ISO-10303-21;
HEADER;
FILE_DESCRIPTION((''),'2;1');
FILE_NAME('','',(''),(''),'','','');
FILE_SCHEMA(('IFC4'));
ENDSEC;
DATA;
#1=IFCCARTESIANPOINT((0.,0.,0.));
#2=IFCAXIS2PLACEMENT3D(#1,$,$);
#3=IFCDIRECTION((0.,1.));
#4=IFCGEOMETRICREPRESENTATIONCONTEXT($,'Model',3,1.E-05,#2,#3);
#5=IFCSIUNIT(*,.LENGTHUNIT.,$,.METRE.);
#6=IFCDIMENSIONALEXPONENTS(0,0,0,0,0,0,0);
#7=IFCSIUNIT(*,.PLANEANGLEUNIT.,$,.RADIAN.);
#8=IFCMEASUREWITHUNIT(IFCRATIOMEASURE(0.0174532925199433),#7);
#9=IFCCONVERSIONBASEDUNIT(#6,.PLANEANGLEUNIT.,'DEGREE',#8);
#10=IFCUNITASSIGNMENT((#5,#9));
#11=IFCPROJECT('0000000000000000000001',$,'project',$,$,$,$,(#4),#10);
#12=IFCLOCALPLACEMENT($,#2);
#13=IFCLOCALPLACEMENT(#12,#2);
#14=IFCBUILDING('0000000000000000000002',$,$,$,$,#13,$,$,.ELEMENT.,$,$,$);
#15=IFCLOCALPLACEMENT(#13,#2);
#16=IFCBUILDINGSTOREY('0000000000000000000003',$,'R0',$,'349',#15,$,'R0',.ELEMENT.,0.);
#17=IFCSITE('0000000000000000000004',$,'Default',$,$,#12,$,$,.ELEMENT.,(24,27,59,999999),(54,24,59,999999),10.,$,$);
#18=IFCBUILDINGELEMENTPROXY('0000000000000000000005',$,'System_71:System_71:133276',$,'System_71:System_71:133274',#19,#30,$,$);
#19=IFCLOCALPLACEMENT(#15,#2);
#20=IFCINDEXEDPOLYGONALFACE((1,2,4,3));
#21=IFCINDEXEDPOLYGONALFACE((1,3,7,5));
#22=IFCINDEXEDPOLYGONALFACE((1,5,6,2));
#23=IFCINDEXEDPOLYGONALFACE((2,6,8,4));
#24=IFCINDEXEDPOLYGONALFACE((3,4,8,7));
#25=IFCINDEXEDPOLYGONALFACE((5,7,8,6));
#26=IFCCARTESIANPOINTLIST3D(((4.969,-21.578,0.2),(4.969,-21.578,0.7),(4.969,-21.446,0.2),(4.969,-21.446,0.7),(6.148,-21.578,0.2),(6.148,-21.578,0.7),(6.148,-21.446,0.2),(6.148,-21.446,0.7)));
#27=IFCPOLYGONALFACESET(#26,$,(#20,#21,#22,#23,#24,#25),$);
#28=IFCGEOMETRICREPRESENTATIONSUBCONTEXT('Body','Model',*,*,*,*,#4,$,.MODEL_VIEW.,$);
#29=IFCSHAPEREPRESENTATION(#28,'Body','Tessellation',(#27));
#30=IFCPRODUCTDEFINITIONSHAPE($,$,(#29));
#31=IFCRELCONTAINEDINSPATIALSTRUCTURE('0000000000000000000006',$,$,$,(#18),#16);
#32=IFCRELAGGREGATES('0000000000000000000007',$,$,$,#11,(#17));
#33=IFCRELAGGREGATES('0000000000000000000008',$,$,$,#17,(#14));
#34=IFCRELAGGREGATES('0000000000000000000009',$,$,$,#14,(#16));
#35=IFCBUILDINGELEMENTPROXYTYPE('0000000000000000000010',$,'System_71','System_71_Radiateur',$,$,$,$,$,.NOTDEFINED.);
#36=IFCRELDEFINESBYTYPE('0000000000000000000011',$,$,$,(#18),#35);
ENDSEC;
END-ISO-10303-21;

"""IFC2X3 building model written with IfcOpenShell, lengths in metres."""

from ifc_helpers import new_model, entity, si_unit, converted_unit, direction, frame, origin, origin_2d_with_axis, place, context, subcontext, project, spatial, rectangle, extrude, source, transform, mapped, type_object, type_shapes, element, save


model = new_model("IFC2X3")

# Units and contexts
model_context = context("Model", 3, precision=1e-05, world=origin(), true_north=direction((0.0, 1.0)))
body_context = subcontext(model_context, "Body", "Model", "MODEL_VIEW")
ifc_project = project(units=[si_unit("LENGTHUNIT", "METRE"), converted_unit("PLANEANGLEUNIT", "DEGREE", entity("IfcRatioMeasure", 0.0174532925199433), si_unit("PLANEANGLEUNIT", "RADIAN"), dimensions=[0, 0, 0, 0, 0, 0, 0])], contexts=[model_context])

# Site, building, storey
site_placement = place(None, origin())
site = spatial("IfcSite", under=ifc_project, at=site_placement, Name="Default", CompositionType="ELEMENT", RefLatitude=(24, 27, 59, 999999), RefLongitude=(54, 24, 59, 999999), RefElevation=10.0)
building_placement = place(site_placement, origin())
building = spatial("IfcBuilding", under=site, at=building_placement, CompositionType="ELEMENT")
storey_placement = place(building_placement, origin())
storey = spatial("IfcBuildingStorey", under=building, at=storey_placement, Name="R0", ObjectType="349", LongName="R0", CompositionType="ELEMENT", Elevation=0.0)

# Building element proxy
building_element_proxy_type_1 = type_object("IfcBuildingElementProxyType", Name="System_71", Description="System_71_Radiateur", PredefinedType="NOTDEFINED")
shared_shape_1 = source(origin(), body_context, "Body", "SweptSolid", [
    extrude(rectangle(XDim=0.132, YDim=1.179, at=origin_2d_with_axis()), frame((5.5585, -21.512, 0.2), z_axis=(0.0, 0.0, 1.0), x_axis=(0.0, 1.0, 0.0)), (0.0, 0.0, 1.0), 0.5),
])
type_shapes(building_element_proxy_type_1, [shared_shape_1])
proxy_1_placement = place(storey_placement, origin())
element("IfcBuildingElementProxy", 1, at=proxy_1_placement, inside=storey, type_object=building_element_proxy_type_1, Name="System_71:System_71:133276", ObjectType="System_71:System_71:133274", context=body_context, shape_type="MappedRepresentation", body=[
    mapped(shared_shape_1, transform((0.0, 0.0, 0.0), scale=1.0)),
])

save(model, "model.ifc")
